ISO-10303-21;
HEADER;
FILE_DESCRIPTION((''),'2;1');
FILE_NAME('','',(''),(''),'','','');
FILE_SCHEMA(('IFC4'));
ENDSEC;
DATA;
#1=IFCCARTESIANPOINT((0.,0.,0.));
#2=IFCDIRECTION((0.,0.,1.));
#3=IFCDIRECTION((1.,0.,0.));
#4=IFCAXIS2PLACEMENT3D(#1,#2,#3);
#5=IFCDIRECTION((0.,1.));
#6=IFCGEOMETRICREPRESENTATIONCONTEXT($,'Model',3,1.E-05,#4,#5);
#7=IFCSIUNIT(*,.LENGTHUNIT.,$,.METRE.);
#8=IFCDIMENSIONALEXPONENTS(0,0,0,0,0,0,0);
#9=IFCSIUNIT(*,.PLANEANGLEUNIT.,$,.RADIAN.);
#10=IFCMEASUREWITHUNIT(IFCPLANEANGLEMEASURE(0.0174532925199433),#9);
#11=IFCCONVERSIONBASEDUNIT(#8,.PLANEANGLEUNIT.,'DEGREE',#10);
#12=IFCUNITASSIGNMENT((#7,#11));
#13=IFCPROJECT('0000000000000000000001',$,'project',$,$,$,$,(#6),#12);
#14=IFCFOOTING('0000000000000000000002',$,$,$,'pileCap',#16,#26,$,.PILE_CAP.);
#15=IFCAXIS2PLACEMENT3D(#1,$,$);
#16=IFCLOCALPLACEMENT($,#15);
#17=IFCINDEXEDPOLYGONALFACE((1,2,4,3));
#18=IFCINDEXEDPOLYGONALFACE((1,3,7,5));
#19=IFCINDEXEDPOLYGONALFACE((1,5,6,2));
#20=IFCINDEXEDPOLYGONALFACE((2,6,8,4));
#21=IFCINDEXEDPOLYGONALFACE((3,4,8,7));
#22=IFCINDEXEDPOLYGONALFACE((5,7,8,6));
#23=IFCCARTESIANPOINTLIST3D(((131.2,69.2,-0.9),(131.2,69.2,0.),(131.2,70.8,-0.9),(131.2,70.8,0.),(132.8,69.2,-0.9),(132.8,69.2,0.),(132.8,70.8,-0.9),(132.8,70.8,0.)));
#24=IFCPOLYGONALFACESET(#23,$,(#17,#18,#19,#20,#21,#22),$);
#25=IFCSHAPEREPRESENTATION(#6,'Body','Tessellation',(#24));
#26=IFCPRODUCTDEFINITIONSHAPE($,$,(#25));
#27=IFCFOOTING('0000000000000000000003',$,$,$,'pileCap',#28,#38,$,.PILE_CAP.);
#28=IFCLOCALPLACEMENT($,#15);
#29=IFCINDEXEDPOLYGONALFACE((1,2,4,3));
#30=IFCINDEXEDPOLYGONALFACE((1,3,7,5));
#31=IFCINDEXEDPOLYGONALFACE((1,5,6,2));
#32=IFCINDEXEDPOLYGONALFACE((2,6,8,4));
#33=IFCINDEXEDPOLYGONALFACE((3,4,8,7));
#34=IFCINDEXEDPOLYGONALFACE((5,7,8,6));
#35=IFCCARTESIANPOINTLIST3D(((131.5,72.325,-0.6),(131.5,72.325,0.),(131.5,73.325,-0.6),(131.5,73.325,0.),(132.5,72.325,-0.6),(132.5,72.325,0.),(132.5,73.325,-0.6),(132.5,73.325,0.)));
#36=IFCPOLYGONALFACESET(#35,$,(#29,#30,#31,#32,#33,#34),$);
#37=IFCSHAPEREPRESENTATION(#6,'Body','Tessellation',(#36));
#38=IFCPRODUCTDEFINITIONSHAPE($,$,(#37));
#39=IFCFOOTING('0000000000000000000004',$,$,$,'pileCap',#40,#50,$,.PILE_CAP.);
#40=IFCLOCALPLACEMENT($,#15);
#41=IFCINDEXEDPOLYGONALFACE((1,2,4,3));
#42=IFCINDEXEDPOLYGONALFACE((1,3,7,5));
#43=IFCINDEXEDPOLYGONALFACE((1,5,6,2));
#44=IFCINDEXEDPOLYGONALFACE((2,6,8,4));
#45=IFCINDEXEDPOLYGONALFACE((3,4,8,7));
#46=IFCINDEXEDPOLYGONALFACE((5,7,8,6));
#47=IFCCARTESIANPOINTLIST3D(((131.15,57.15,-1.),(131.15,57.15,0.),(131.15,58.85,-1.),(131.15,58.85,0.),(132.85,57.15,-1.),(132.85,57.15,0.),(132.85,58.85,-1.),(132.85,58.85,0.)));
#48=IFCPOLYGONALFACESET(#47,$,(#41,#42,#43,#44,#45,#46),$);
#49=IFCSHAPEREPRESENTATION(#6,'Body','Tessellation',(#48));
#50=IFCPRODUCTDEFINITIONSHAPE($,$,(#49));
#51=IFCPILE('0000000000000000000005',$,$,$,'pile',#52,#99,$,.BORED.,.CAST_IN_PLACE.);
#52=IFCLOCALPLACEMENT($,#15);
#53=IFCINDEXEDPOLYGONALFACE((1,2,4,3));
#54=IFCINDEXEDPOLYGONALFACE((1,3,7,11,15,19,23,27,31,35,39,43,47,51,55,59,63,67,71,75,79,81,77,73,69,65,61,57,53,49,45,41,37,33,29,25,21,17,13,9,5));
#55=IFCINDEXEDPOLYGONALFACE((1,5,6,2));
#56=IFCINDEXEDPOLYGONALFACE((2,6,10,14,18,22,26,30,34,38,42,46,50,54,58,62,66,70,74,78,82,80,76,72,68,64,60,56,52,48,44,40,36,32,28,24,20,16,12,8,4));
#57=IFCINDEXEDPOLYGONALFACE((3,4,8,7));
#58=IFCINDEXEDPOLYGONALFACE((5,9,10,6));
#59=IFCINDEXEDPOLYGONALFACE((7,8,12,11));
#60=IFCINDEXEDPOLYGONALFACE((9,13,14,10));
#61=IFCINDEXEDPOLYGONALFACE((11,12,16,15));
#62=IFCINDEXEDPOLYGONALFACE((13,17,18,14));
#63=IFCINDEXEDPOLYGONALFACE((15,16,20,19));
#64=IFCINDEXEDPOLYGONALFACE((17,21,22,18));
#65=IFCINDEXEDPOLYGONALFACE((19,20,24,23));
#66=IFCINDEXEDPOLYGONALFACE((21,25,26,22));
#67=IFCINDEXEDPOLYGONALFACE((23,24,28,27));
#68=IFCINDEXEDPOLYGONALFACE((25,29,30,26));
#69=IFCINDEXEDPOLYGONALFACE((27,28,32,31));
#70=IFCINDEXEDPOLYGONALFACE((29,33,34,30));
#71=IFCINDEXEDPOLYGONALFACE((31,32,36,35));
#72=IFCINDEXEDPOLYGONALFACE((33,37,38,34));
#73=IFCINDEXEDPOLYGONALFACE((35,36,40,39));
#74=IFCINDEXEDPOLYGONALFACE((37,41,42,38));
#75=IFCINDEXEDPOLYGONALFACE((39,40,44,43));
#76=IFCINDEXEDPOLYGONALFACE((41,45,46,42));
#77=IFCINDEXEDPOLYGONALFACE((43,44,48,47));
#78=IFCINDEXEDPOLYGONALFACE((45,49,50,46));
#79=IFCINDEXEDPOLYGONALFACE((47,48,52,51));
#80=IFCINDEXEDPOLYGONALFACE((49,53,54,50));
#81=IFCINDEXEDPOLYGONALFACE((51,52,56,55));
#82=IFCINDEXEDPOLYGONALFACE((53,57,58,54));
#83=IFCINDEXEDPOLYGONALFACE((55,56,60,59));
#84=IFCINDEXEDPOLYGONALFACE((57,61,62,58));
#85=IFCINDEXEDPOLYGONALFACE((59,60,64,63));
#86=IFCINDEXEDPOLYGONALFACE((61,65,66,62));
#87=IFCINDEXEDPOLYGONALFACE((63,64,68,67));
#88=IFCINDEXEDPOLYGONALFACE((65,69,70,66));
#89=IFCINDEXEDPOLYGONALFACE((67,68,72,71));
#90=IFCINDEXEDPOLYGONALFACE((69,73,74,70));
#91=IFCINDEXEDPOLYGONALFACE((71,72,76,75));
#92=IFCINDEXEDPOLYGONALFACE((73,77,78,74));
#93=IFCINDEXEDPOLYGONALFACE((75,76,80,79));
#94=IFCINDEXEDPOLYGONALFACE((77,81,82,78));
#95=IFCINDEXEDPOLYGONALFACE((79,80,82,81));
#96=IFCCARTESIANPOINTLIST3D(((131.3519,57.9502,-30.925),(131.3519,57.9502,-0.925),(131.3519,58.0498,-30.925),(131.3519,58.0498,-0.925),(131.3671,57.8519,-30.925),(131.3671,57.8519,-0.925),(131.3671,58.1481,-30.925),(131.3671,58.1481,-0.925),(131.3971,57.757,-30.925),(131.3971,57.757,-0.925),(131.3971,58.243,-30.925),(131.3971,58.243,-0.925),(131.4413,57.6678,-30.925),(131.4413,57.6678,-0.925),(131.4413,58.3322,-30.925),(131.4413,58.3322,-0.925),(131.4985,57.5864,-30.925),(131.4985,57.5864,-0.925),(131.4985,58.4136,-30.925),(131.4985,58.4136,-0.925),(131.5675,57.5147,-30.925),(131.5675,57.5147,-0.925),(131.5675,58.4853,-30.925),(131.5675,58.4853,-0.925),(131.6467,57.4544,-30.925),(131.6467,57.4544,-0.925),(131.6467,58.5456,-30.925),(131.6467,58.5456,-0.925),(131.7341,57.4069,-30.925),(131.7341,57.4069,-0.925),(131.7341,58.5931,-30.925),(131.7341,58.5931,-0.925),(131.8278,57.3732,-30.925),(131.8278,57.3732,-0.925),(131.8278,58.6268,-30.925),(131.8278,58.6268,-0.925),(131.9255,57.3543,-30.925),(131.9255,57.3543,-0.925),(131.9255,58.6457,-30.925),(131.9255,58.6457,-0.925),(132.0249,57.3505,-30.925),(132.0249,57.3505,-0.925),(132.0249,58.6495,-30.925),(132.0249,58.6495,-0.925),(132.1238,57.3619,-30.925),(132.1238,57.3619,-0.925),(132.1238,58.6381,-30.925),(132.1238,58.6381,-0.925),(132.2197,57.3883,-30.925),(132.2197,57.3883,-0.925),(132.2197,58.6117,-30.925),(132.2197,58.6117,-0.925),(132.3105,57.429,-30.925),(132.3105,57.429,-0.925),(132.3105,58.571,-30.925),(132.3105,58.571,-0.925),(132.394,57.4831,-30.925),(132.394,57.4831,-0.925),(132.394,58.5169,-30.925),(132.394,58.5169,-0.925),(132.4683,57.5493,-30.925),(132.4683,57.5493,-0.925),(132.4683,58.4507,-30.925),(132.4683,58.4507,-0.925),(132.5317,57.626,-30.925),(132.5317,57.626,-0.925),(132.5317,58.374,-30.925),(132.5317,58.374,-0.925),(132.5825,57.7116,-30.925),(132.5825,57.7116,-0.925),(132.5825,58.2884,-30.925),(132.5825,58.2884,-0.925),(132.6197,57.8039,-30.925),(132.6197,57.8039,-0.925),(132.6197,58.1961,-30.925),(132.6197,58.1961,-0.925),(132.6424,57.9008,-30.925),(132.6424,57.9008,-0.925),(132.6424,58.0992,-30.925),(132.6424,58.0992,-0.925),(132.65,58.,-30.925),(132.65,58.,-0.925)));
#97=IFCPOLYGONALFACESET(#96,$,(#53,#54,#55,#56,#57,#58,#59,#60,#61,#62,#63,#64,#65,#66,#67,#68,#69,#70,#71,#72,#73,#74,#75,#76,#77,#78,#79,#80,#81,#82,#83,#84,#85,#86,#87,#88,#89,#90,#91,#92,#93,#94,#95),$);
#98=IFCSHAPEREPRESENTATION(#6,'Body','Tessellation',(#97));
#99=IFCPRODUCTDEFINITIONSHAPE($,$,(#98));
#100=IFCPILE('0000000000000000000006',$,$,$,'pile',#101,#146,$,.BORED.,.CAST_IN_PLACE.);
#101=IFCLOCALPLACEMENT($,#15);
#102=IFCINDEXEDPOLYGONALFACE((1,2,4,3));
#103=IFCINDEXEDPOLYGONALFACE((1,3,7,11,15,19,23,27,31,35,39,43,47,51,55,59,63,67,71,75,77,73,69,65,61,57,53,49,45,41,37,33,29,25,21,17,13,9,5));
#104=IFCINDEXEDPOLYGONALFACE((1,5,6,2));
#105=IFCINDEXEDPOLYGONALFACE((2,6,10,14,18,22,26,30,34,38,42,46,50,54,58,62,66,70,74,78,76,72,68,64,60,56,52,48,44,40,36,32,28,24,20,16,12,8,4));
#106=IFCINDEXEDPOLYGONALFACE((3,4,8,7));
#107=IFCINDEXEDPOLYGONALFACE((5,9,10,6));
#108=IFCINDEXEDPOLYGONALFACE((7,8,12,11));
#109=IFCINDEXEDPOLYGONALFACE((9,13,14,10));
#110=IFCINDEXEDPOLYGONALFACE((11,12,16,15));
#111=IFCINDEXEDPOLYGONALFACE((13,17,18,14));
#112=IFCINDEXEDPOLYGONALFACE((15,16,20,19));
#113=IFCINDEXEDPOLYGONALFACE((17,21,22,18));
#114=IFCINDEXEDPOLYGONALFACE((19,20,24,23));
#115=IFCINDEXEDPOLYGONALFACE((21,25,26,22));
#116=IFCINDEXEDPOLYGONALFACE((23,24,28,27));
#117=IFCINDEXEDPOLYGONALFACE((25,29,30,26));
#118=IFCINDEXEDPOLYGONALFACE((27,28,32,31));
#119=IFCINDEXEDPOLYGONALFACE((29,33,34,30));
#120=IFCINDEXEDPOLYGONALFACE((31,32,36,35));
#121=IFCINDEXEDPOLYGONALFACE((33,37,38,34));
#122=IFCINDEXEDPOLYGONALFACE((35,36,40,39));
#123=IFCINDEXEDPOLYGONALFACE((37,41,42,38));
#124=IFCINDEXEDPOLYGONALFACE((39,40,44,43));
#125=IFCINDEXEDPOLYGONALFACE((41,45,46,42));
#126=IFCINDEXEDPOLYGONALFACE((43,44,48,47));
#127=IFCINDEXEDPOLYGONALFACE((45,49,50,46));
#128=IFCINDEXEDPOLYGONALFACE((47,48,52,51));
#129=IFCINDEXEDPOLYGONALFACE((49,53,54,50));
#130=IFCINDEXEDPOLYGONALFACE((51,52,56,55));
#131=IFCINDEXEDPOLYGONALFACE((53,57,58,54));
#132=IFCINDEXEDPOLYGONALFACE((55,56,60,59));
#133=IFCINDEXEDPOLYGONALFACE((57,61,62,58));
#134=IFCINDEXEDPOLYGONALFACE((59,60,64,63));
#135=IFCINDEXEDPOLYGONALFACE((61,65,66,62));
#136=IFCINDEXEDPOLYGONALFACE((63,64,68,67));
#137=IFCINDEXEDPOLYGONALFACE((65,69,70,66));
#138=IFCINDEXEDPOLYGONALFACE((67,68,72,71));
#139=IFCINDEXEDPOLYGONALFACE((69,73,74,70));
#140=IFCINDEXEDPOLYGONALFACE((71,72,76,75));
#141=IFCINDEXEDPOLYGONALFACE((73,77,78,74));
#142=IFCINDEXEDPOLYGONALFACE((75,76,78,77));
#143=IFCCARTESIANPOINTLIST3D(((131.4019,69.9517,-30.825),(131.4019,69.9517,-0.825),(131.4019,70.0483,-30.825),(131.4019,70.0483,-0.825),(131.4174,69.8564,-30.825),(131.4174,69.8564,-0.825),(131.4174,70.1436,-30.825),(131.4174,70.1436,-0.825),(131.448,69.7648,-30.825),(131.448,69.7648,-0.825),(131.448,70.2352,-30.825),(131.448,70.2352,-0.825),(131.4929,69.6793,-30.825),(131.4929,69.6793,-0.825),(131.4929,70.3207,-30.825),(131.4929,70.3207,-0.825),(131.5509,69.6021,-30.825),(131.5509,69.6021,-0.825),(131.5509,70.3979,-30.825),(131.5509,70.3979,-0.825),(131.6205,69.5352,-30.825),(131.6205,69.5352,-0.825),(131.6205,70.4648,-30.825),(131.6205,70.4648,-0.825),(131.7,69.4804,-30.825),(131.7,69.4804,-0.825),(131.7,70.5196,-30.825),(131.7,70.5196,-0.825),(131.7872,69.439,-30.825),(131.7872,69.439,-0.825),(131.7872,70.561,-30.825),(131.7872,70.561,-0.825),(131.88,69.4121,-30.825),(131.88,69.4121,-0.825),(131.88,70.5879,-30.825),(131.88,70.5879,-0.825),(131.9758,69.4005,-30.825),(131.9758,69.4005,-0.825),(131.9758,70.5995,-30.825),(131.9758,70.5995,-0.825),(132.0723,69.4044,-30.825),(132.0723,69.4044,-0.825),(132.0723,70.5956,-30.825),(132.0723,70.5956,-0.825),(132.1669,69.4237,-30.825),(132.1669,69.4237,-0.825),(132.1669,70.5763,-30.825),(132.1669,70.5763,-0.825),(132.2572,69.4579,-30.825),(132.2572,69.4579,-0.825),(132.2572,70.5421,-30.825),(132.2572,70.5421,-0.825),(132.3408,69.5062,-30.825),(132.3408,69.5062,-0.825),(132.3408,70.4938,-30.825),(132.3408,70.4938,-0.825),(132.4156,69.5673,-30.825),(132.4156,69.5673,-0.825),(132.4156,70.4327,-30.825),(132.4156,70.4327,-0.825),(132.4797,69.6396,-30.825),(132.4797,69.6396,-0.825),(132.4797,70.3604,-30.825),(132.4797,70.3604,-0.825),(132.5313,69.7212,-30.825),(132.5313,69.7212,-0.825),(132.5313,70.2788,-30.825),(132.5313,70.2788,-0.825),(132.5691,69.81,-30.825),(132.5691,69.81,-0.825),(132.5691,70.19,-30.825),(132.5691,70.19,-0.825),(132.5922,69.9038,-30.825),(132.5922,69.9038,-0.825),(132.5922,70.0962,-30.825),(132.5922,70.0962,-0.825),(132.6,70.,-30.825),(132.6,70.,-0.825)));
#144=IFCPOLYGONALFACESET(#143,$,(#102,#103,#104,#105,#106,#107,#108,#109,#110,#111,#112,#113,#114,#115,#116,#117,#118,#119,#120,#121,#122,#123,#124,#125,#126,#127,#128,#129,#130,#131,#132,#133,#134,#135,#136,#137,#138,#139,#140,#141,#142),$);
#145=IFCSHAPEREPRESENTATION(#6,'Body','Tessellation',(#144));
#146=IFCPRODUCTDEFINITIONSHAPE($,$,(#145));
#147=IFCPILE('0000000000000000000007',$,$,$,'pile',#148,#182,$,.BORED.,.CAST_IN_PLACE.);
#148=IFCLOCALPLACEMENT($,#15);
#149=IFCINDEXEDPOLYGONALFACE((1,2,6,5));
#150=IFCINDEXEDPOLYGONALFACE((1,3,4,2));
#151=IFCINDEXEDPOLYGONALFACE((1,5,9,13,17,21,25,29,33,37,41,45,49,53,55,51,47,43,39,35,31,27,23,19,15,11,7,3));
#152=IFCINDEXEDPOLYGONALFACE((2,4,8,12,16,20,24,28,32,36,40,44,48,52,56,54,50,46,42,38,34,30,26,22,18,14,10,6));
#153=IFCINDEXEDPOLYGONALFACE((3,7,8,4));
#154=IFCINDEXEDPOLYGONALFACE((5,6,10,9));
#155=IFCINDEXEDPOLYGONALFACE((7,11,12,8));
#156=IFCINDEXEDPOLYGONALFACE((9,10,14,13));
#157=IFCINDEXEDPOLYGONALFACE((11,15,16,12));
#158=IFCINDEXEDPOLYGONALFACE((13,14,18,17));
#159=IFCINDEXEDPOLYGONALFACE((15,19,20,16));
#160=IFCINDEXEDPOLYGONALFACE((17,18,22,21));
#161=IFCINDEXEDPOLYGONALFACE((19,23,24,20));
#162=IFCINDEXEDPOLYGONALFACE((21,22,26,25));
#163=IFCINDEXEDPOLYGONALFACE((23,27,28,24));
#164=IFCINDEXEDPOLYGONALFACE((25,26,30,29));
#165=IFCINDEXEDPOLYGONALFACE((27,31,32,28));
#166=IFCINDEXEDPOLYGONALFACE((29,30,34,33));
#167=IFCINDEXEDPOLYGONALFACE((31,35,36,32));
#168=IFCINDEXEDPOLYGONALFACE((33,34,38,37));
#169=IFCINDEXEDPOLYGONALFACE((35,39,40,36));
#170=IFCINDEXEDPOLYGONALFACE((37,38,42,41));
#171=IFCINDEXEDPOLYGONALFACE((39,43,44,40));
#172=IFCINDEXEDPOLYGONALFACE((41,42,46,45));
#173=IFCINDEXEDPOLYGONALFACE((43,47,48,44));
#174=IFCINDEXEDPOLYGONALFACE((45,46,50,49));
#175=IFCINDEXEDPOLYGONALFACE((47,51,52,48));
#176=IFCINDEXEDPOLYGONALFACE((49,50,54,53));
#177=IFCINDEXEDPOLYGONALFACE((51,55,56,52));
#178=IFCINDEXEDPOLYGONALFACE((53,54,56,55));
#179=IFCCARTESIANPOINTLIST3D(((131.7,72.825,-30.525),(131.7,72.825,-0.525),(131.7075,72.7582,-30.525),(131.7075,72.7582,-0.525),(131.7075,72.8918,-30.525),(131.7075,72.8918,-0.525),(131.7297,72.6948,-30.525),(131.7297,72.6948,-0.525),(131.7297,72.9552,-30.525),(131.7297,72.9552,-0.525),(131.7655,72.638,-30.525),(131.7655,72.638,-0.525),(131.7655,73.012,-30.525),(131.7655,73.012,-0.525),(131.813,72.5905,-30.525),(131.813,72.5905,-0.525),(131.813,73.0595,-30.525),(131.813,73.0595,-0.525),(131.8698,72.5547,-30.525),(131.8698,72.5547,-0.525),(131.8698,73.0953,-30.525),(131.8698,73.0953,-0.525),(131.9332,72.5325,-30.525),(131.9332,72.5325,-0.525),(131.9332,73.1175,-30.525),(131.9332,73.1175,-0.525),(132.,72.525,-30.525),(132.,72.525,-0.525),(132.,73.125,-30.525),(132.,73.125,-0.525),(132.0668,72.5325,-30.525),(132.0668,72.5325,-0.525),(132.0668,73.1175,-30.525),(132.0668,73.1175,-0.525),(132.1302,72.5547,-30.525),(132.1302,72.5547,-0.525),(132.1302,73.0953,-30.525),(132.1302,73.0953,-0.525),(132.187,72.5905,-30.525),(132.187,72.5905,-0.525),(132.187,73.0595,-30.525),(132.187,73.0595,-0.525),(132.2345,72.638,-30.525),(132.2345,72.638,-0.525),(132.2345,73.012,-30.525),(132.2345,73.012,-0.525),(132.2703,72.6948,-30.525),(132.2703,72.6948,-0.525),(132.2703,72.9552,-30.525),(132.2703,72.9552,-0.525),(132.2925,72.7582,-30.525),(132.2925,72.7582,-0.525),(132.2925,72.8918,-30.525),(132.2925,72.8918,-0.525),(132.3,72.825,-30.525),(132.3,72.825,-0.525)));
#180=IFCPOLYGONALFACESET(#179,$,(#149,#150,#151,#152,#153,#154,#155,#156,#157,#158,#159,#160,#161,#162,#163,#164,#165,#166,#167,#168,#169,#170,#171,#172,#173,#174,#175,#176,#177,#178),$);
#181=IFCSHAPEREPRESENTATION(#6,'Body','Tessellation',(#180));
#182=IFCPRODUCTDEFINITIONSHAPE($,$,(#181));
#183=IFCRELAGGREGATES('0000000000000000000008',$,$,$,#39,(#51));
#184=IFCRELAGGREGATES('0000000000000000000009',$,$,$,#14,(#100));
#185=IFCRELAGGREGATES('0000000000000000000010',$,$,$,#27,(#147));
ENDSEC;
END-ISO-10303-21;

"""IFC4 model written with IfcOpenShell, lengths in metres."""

from ifc_helpers import new_model, entity, si_unit, converted_unit, direction, frame, origin_with_axes, place, context, project, polyline, circle_curve, parameter, trimmed, segment, composite_curve, outline, extrude, element, aggregate, save


model = new_model("IFC4")

# Units and contexts
model_context = context("Model", 3, precision=1e-05, world=origin_with_axes(), true_north=direction((0.0, 1.0)))
ifc_project = project(units=[si_unit("LENGTHUNIT", "METRE"), converted_unit("PLANEANGLEUNIT", "DEGREE", entity("IfcPlaneAngleMeasure", 0.0174532925199433), si_unit("PLANEANGLEUNIT", "RADIAN"), dimensions=[0, 0, 0, 0, 0, 0, 0])], contexts=[model_context])

# Footings
placement_1 = place(None, origin_with_axes())
placement_2 = place(placement_1, origin_with_axes())
footing_1_placement = place(placement_2, frame((132.0, 70.0, -0.9), z_axis=(0.0, 0.0, 1.0), x_axis=(1.0, 0.0, 0.0)))
footing_1 = element("IfcFooting", 1, at=footing_1_placement, ObjectType="pileCap", PredefinedType="PILE_CAP", context=model_context, body=[
    extrude(outline(polyline([(0.8, -0.8, 0.0), (0.8, 0.8, 0.0), (-0.8, 0.8, 0.0), (-0.8, -0.8, 0.0), (0.8, -0.8, 0.0)])), origin_with_axes(), (0.0, 0.0, 1.0), 0.9),
])
footing_2_placement = place(placement_2, frame((132.0, 72.825, -0.6), z_axis=(0.0, 0.0, 1.0), x_axis=(1.0, 0.0, 0.0)))
footing_2 = element("IfcFooting", 2, at=footing_2_placement, ObjectType="pileCap", PredefinedType="PILE_CAP", context=model_context, body=[
    extrude(outline(polyline([(0.5, -0.5, 0.0), (0.5, 0.5, 0.0), (-0.5, 0.5, 0.0), (-0.5, -0.5, 0.0), (0.5, -0.5, 0.0)])), origin_with_axes(), (0.0, 0.0, 1.0), 0.6),
])
footing_3_placement = place(placement_2, frame((132.0, 58.0, -1.0), z_axis=(0.0, 0.0, 1.0), x_axis=(1.0, 0.0, 0.0)))
footing_3 = element("IfcFooting", 3, at=footing_3_placement, ObjectType="pileCap", PredefinedType="PILE_CAP", context=model_context, body=[
    extrude(outline(polyline([(0.85, -0.85, 0.0), (0.85, 0.85, 0.0), (-0.85, 0.85, 0.0), (-0.85, -0.85, 0.0), (0.85, -0.85, 0.0)])), origin_with_axes(), (0.0, 0.0, 1.0), 1.0),
])

# Piles
pile_1_placement = place(footing_3_placement, frame((0.0, 0.0, -29.925), z_axis=(0.0, 0.0, 1.0), x_axis=(1.0, 0.0, 0.0)))
pile_1 = element("IfcPile", 4, at=pile_1_placement, ObjectType="pile", ConstructionType="CAST_IN_PLACE", PredefinedType="BORED", context=model_context, body=[
    extrude(outline(composite_curve([segment(trimmed(circle_curve(origin_with_axes(), 0.65), [parameter(0.0)], [parameter(360.0)], True, "PARAMETER"), True, "CONTINUOUS")], self_intersect=False)), origin_with_axes(), (0.0, 0.0, 1.0), 30.0),
])
aggregate(footing_3, [pile_1])
pile_2_placement = place(footing_1_placement, frame((0.0, 0.0, -29.925), z_axis=(0.0, 0.0, 1.0), x_axis=(1.0, 0.0, 0.0)))
pile_2 = element("IfcPile", 5, at=pile_2_placement, ObjectType="pile", ConstructionType="CAST_IN_PLACE", PredefinedType="BORED", context=model_context, body=[
    extrude(outline(composite_curve([segment(trimmed(circle_curve(origin_with_axes(), 0.6), [parameter(0.0)], [parameter(360.0)], True, "PARAMETER"), True, "CONTINUOUS")], self_intersect=False)), origin_with_axes(), (0.0, 0.0, 1.0), 30.0),
])
aggregate(footing_1, [pile_2])
pile_3_placement = place(footing_2_placement, frame((0.0, 0.0, -29.925), z_axis=(0.0, 0.0, 1.0), x_axis=(1.0, 0.0, 0.0)))
pile_3 = element("IfcPile", 6, at=pile_3_placement, ObjectType="pile", ConstructionType="CAST_IN_PLACE", PredefinedType="BORED", context=model_context, body=[
    extrude(outline(composite_curve([segment(trimmed(circle_curve(origin_with_axes(), 0.3), [parameter(0.0)], [parameter(360.0)], True, "PARAMETER"), True, "CONTINUOUS")], self_intersect=False)), origin_with_axes(), (0.0, 0.0, 1.0), 30.0),
])
aggregate(footing_2, [pile_3])

save(model, "model.ifc")
